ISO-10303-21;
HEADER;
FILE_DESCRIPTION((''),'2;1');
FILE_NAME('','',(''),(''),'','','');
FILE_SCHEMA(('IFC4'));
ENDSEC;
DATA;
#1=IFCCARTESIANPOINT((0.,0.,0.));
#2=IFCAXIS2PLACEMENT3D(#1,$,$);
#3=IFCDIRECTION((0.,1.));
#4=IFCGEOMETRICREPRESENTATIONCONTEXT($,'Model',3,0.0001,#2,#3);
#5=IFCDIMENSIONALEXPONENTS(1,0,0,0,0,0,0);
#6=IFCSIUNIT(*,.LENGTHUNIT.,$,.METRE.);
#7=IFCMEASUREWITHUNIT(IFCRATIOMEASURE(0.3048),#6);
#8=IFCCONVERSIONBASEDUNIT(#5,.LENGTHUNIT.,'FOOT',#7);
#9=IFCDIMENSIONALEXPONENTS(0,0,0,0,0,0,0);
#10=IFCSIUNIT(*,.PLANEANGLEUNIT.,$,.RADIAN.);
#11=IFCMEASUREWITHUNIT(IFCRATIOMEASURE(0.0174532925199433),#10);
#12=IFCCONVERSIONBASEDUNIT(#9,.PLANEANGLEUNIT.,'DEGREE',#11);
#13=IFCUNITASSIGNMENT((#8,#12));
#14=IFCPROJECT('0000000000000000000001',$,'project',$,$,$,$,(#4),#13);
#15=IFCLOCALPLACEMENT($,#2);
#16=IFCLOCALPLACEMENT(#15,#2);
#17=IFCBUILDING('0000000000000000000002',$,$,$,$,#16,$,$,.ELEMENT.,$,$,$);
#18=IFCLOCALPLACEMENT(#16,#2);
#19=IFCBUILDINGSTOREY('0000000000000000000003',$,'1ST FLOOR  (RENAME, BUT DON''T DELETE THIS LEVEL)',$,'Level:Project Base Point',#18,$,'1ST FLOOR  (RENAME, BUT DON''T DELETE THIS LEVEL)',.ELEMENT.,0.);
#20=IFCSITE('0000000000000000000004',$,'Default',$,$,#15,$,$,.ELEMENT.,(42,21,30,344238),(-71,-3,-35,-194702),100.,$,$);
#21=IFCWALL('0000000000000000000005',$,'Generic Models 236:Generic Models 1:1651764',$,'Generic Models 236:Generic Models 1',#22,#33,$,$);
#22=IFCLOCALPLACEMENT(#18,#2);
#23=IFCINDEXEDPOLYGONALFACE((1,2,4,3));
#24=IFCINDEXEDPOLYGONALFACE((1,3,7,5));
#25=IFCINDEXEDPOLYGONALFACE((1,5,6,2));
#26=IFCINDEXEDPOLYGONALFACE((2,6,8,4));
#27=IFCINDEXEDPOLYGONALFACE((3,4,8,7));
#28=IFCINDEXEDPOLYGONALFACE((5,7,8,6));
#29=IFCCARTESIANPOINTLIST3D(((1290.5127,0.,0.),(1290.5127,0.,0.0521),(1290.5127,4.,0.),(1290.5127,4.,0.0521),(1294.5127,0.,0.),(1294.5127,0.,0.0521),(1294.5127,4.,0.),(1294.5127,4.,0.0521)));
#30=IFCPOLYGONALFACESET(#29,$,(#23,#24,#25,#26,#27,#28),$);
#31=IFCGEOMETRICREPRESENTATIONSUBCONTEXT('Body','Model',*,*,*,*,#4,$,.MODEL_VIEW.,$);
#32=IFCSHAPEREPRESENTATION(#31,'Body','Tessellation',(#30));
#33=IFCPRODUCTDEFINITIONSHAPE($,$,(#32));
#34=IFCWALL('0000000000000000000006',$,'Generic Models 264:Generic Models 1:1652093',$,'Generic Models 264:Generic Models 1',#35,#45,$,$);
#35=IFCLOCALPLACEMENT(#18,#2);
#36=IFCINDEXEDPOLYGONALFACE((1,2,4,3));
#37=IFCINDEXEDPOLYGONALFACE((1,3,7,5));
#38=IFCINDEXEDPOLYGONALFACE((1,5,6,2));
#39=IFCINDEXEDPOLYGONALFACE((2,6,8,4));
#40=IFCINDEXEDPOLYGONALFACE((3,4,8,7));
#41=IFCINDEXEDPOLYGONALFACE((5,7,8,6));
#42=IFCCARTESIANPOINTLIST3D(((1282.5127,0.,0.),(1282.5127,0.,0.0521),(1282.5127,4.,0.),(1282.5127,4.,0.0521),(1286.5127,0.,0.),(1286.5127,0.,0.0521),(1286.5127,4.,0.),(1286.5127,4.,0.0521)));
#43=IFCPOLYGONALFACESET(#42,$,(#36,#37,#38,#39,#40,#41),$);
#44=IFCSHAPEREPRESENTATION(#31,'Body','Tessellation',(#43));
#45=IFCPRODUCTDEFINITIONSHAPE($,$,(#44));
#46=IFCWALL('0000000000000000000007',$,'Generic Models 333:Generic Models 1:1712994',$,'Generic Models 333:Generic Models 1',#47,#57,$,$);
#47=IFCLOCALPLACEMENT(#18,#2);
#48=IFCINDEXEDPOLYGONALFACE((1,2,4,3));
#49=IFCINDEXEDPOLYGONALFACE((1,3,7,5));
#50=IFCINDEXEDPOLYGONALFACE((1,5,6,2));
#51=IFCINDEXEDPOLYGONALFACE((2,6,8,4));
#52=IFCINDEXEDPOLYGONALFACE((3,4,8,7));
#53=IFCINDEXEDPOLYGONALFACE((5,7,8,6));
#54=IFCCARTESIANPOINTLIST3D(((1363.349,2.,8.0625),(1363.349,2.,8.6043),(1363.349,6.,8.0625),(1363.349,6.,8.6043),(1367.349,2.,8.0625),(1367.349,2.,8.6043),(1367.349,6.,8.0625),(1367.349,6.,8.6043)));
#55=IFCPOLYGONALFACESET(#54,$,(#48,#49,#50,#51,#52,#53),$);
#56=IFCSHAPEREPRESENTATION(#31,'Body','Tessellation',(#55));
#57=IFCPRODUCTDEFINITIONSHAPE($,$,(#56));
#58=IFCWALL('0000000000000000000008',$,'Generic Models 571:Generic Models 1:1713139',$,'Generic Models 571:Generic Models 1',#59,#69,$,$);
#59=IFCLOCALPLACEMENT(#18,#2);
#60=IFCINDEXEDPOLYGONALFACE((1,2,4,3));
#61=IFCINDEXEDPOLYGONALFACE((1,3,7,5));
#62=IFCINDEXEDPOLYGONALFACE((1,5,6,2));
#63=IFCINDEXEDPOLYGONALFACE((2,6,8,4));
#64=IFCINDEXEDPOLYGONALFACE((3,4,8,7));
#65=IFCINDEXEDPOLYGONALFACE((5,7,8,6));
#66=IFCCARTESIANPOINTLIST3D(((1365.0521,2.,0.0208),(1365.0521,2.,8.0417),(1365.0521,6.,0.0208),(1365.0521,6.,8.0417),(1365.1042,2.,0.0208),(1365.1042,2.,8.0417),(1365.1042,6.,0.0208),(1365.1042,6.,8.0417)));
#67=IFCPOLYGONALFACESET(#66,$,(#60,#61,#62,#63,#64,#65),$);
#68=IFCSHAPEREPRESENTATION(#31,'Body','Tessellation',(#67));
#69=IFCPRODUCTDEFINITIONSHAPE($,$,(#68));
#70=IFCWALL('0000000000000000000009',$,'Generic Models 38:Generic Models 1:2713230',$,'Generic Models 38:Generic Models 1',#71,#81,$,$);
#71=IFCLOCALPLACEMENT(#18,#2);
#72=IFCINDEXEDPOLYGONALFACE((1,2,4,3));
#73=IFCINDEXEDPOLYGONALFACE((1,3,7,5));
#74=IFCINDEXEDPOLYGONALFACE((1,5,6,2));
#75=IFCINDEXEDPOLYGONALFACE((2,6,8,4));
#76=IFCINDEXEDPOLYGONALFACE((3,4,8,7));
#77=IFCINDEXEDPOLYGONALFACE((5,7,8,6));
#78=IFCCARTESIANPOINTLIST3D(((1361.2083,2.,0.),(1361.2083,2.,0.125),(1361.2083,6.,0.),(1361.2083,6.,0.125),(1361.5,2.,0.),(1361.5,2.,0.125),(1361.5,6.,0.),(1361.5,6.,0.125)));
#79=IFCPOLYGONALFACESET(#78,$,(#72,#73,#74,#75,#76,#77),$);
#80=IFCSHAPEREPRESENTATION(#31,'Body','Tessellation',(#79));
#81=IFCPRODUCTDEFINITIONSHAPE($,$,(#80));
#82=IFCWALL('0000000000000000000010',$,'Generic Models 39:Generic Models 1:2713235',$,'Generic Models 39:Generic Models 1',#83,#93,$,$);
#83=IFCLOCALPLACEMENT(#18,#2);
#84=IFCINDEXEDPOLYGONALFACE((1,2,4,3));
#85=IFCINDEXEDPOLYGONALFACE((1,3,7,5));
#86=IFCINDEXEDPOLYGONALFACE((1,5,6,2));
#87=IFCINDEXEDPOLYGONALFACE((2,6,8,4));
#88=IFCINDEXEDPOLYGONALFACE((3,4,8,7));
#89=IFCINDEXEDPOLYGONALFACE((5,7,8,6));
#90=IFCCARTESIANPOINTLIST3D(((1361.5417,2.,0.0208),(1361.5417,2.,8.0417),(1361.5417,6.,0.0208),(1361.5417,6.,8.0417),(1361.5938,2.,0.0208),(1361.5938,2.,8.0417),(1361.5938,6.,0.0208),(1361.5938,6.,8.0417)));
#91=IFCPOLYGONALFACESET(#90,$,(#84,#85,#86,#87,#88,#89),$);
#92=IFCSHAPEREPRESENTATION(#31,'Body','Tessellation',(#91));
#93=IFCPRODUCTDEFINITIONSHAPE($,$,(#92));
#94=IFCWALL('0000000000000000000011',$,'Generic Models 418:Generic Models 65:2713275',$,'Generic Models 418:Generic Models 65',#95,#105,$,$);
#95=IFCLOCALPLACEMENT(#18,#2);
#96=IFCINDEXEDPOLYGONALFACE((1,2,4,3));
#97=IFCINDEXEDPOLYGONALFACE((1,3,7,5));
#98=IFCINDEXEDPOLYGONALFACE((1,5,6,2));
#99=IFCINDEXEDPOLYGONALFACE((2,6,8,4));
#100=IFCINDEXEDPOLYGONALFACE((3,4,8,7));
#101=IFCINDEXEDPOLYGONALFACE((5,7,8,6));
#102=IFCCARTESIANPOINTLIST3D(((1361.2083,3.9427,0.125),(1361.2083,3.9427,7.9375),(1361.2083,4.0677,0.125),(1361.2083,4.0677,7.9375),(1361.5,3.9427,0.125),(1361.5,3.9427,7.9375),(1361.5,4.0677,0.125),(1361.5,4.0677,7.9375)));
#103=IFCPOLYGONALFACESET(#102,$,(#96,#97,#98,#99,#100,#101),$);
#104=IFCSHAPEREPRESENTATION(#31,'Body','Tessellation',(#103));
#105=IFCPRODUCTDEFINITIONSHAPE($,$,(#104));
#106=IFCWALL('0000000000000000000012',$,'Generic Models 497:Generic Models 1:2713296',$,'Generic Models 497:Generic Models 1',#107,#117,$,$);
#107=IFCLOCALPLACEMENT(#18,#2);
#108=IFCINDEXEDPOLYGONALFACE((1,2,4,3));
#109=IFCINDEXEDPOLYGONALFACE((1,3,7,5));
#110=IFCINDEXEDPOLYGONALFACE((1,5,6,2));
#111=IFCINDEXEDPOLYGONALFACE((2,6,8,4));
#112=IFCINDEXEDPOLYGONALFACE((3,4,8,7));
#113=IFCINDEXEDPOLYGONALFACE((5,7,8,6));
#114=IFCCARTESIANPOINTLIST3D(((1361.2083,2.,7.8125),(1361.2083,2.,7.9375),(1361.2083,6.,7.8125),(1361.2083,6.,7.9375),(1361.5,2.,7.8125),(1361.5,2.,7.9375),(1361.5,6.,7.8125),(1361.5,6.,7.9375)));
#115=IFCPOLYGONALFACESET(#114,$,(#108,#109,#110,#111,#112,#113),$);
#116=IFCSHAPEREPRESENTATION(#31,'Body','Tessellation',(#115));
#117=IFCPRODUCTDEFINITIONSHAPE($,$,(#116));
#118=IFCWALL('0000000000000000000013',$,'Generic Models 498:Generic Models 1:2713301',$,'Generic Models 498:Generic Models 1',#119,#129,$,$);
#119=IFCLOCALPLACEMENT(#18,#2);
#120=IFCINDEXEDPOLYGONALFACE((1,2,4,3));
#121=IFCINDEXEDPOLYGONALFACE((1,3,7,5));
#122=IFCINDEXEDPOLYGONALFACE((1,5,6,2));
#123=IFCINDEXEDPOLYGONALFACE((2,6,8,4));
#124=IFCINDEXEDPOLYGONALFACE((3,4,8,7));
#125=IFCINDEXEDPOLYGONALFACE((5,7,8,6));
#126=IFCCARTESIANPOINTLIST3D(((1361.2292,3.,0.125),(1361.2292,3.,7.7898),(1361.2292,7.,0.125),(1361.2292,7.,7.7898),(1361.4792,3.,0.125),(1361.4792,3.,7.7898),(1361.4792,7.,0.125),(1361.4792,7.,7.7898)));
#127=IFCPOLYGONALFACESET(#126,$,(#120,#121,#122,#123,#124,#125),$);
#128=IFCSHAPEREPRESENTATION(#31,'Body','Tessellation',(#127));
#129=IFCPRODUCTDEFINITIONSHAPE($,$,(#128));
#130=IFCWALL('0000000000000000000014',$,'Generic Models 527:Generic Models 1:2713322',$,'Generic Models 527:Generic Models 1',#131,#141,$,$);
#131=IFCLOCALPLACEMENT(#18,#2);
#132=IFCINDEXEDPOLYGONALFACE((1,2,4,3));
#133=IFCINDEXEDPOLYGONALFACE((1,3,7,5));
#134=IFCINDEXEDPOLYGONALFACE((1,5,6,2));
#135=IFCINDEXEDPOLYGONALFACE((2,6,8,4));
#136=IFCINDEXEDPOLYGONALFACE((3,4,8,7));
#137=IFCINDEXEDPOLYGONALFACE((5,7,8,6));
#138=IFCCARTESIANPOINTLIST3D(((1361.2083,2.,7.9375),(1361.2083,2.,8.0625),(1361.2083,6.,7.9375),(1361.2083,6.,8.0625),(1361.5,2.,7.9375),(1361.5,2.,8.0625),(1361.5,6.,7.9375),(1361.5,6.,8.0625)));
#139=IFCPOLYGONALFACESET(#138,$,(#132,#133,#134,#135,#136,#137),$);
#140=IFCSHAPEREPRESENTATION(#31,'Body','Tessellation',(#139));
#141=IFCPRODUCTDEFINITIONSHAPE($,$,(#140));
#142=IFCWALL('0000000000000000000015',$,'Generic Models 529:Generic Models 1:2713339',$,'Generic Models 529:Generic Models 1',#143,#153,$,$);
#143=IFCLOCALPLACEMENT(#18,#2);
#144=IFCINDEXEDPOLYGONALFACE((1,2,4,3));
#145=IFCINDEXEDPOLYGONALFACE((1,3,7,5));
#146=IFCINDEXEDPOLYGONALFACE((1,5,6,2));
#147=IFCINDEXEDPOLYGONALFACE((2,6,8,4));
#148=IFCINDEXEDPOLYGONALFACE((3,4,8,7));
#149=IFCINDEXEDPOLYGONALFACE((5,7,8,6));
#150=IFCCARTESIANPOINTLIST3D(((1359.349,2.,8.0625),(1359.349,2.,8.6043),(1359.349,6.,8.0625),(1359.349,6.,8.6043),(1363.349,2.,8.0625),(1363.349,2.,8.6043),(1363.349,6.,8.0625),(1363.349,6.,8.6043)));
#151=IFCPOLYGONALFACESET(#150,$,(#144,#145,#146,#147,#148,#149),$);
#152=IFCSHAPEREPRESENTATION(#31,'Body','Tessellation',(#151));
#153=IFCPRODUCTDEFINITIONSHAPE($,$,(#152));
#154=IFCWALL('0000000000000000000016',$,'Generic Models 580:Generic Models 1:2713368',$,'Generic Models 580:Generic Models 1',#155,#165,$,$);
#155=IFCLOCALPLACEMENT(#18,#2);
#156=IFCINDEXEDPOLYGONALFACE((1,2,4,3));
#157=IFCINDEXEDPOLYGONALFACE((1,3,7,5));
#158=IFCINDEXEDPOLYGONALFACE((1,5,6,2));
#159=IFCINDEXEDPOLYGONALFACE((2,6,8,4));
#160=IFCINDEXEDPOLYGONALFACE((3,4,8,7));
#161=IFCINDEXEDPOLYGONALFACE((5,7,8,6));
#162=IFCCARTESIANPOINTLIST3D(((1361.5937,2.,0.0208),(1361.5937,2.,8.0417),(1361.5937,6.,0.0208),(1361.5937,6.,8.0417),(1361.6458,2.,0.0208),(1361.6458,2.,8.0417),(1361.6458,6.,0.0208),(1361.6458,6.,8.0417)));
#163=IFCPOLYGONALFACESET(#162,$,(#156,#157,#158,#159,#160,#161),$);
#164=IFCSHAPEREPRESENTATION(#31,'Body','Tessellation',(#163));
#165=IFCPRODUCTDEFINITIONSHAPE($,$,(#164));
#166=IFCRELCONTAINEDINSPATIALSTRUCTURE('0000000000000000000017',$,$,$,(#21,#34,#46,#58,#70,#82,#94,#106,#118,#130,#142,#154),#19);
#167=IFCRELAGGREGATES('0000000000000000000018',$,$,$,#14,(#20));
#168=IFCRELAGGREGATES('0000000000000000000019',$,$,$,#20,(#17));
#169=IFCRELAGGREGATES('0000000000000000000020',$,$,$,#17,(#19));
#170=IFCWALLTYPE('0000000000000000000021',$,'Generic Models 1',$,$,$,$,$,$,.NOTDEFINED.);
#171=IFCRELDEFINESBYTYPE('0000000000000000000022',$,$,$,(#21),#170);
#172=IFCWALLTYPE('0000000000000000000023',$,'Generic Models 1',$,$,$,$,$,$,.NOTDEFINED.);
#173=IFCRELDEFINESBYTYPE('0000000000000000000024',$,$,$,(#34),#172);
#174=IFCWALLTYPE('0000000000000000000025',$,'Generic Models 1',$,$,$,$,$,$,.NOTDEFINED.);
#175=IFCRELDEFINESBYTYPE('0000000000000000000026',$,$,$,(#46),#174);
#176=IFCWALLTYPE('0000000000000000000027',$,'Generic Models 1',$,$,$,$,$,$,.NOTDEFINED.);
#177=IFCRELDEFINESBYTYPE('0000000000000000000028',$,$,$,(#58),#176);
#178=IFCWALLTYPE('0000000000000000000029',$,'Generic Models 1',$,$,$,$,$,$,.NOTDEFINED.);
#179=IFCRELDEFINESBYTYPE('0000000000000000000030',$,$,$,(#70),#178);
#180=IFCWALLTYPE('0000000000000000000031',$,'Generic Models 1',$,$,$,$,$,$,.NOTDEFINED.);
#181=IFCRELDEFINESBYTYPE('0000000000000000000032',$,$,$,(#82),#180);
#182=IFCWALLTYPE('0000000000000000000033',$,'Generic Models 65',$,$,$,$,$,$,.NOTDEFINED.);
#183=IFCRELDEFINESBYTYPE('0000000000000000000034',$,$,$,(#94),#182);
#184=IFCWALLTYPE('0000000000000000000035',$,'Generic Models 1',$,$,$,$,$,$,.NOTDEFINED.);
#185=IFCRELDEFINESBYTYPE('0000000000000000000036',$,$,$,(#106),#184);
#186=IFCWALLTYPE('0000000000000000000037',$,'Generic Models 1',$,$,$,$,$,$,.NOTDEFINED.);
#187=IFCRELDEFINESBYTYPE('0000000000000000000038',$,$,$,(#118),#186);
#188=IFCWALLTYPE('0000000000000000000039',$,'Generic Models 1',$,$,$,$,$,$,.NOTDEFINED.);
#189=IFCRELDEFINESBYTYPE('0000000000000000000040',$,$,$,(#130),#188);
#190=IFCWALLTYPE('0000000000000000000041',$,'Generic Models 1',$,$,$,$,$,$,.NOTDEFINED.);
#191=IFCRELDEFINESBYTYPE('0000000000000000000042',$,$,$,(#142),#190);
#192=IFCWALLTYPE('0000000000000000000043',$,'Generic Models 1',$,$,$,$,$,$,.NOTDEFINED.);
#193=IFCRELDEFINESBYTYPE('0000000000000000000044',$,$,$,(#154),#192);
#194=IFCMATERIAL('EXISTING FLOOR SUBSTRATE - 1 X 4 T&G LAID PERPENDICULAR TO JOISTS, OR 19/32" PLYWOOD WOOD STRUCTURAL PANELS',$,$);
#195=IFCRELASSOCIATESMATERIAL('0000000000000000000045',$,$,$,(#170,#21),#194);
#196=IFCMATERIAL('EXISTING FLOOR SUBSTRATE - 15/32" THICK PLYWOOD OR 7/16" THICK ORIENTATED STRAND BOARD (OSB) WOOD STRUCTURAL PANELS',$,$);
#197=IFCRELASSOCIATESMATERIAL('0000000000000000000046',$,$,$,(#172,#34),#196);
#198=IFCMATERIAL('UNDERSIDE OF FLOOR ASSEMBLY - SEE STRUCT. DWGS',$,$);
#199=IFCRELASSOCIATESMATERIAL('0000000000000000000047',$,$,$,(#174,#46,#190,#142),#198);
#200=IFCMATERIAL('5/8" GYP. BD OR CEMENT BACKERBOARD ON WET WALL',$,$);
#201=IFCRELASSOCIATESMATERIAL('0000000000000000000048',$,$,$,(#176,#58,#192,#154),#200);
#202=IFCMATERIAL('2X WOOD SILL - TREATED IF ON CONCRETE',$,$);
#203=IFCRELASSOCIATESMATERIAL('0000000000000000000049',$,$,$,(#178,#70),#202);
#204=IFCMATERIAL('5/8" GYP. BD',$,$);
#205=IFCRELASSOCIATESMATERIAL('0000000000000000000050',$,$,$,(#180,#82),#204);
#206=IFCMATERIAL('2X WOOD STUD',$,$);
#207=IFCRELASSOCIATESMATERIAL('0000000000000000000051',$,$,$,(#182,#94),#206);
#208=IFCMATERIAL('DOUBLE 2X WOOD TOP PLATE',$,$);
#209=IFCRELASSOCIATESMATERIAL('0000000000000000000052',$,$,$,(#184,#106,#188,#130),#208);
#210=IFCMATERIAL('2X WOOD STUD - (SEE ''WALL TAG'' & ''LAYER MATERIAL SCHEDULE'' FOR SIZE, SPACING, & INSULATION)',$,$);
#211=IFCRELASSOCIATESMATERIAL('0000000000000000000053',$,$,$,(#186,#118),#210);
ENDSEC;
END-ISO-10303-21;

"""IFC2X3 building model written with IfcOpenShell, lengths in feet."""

from ifc_helpers import new_model, entity, si_unit, converted_unit, direction, frame, frame_2d, origin, origin_2d_with_axis, place, context, subcontext, project, spatial, rectangle, extrude, material, type_object, element, save


model = new_model("IFC2X3")

# Units and contexts
model_context = context("Model", 3, precision=0.0001, world=origin(), true_north=direction((0.0, 1.0)))
body_context = subcontext(model_context, "Body", "Model", "MODEL_VIEW")
ifc_project = project(units=[converted_unit("LENGTHUNIT", "FOOT", entity("IfcRatioMeasure", 0.3048), si_unit("LENGTHUNIT", "METRE"), dimensions=[1, 0, 0, 0, 0, 0, 0]), converted_unit("PLANEANGLEUNIT", "DEGREE", entity("IfcRatioMeasure", 0.0174532925199433), si_unit("PLANEANGLEUNIT", "RADIAN"), dimensions=[0, 0, 0, 0, 0, 0, 0])], contexts=[model_context])

# Site, building, storey
site_placement = place(None, origin())
site = spatial("IfcSite", under=ifc_project, at=site_placement, Name="Default", CompositionType="ELEMENT", RefLatitude=(42, 21, 30, 344238), RefLongitude=(-71, -3, -35, -194702), RefElevation=100.0)
building_placement = place(site_placement, origin())
building = spatial("IfcBuilding", under=site, at=building_placement, CompositionType="ELEMENT")
storey_placement = place(building_placement, origin())
storey = spatial("IfcBuildingStorey", under=building, at=storey_placement, Name="1ST FLOOR  (RENAME, BUT DON'T DELETE THIS LEVEL)", ObjectType="Level:Project Base Point", LongName="1ST FLOOR  (RENAME, BUT DON'T DELETE THIS LEVEL)", CompositionType="ELEMENT", Elevation=0.0)

# Walls
ifc_material_1 = material(Name="EXISTING FLOOR SUBSTRATE - 1 X 4 T&G LAID PERPENDICULAR TO JOISTS, OR 19/32\" PLYWOOD WOOD STRUCTURAL PANELS")
wall_type_1 = type_object("IfcWallType", Name="Generic Models 1", PredefinedType="NOTDEFINED", material=ifc_material_1)
wall_1_placement = place(storey_placement, frame((1290.5127, 0.0, 0.0), z_axis=(0.0, 0.0, 1.0), x_axis=(0.0, 1.0, 0.0)))
element("IfcWall", 1, at=wall_1_placement, inside=storey, type_object=wall_type_1, material=ifc_material_1, Name="Generic Models 236:Generic Models 1:1651764", ObjectType="Generic Models 236:Generic Models 1", context=body_context, shape_type="SweptSolid", body=[
    extrude(rectangle(XDim=4.0, YDim=4.0, at=origin_2d_with_axis()), frame((2.0, -2.0, 0.0)), (0.0, 0.0, 1.0), 0.0521),
])
ifc_material_2 = material(Name="EXISTING FLOOR SUBSTRATE - 15/32\" THICK PLYWOOD OR 7/16\" THICK ORIENTATED STRAND BOARD (OSB) WOOD STRUCTURAL PANELS")
wall_type_2 = type_object("IfcWallType", Name="Generic Models 1", PredefinedType="NOTDEFINED", material=ifc_material_2)
wall_2_placement = place(storey_placement, frame((1282.5127, 0.0, 0.0), z_axis=(0.0, 0.0, 1.0), x_axis=(0.0, 1.0, 0.0)))
element("IfcWall", 2, at=wall_2_placement, inside=storey, type_object=wall_type_2, material=ifc_material_2, Name="Generic Models 264:Generic Models 1:1652093", ObjectType="Generic Models 264:Generic Models 1", context=body_context, shape_type="SweptSolid", body=[
    extrude(rectangle(XDim=4.0, YDim=4.0, at=origin_2d_with_axis()), frame((2.0, -2.0, 0.0)), (0.0, 0.0, 1.0), 0.0521),
])
ifc_material_3 = material(Name="UNDERSIDE OF FLOOR ASSEMBLY - SEE STRUCT. DWGS")
wall_type_3 = type_object("IfcWallType", Name="Generic Models 1", PredefinedType="NOTDEFINED", material=ifc_material_3)
wall_3_placement = place(storey_placement, frame((1363.349, 2.0, 8.0625), z_axis=(0.0, 0.0, 1.0), x_axis=(0.0, 1.0, 0.0)))
element("IfcWall", 3, at=wall_3_placement, inside=storey, type_object=wall_type_3, material=ifc_material_3, Name="Generic Models 333:Generic Models 1:1712994", ObjectType="Generic Models 333:Generic Models 1", context=body_context, shape_type="SweptSolid", body=[
    extrude(rectangle(XDim=4.0, YDim=4.0, at=origin_2d_with_axis()), frame((2.0, -2.0, 0.0)), (0.0, 0.0, 1.0), 0.5418),
])
ifc_material_4 = material(Name="5/8\" GYP. BD OR CEMENT BACKERBOARD ON WET WALL")
wall_type_4 = type_object("IfcWallType", Name="Generic Models 1", PredefinedType="NOTDEFINED", material=ifc_material_4)
wall_4_placement = place(storey_placement, frame((1365.0521, 2.0, 0.0208), z_axis=(0.0, 0.0, 1.0), x_axis=(0.0, 1.0, 0.0)))
element("IfcWall", 4, at=wall_4_placement, inside=storey, type_object=wall_type_4, material=ifc_material_4, Name="Generic Models 571:Generic Models 1:1713139", ObjectType="Generic Models 571:Generic Models 1", context=body_context, shape_type="SweptSolid", body=[
    extrude(rectangle(XDim=4.0, YDim=0.0521, at=origin_2d_with_axis()), frame((2.0, -0.026, 0.0)), (0.0, 0.0, 1.0), 8.0208),
])
ifc_material_5 = material(Name="2X WOOD SILL - TREATED IF ON CONCRETE")
wall_type_5 = type_object("IfcWallType", Name="Generic Models 1", PredefinedType="NOTDEFINED", material=ifc_material_5)
wall_5_placement = place(storey_placement, frame((1361.2083, 2.0, 0.0), z_axis=(0.0, 0.0, 1.0), x_axis=(0.0, 1.0, 0.0)))
element("IfcWall", 5, at=wall_5_placement, inside=storey, type_object=wall_type_5, material=ifc_material_5, Name="Generic Models 38:Generic Models 1:2713230", ObjectType="Generic Models 38:Generic Models 1", context=body_context, shape_type="SweptSolid", body=[
    extrude(rectangle(XDim=4.0, YDim=0.2917, at=frame_2d((0.0, 0.0), x_axis=(1.0, 0.0))), frame((2.0, -0.1458, 0.0)), (0.0, 0.0, 1.0), 0.125),
])
ifc_material_6 = material(Name="5/8\" GYP. BD")
wall_type_6 = type_object("IfcWallType", Name="Generic Models 1", PredefinedType="NOTDEFINED", material=ifc_material_6)
wall_6_placement = place(storey_placement, frame((1361.5417, 2.0, 0.0208), z_axis=(0.0, 0.0, 1.0), x_axis=(0.0, 1.0, 0.0)))
element("IfcWall", 6, at=wall_6_placement, inside=storey, type_object=wall_type_6, material=ifc_material_6, Name="Generic Models 39:Generic Models 1:2713235", ObjectType="Generic Models 39:Generic Models 1", context=body_context, shape_type="SweptSolid", body=[
    extrude(rectangle(XDim=4.0, YDim=0.0521, at=frame_2d((0.0, 0.0), x_axis=(1.0, 0.0))), frame((2.0, -0.026, 0.0)), (0.0, 0.0, 1.0), 8.0208),
])
ifc_material_7 = material(Name="2X WOOD STUD")
wall_type_7 = type_object("IfcWallType", Name="Generic Models 65", PredefinedType="NOTDEFINED", material=ifc_material_7)
wall_7_placement = place(storey_placement, frame((1361.2083, 3.9427, 0.125)))
element("IfcWall", 7, at=wall_7_placement, inside=storey, type_object=wall_type_7, material=ifc_material_7, Name="Generic Models 418:Generic Models 65:2713275", ObjectType="Generic Models 418:Generic Models 65", context=body_context, shape_type="SweptSolid", body=[
    extrude(rectangle(XDim=0.125, YDim=0.2917, at=frame_2d((0.0, 0.0), x_axis=(1.0, 0.0))), frame((0.1458, 0.0625, 0.0), z_axis=(0.0, 0.0, 1.0), x_axis=(0.0, 1.0, 0.0)), (0.0, 0.0, 1.0), 7.8125),
])
ifc_material_8 = material(Name="DOUBLE 2X WOOD TOP PLATE")
wall_type_8 = type_object("IfcWallType", Name="Generic Models 1", PredefinedType="NOTDEFINED", material=ifc_material_8)
wall_8_placement = place(storey_placement, frame((1361.2083, 2.0, 7.8125), z_axis=(0.0, 0.0, 1.0), x_axis=(0.0, 1.0, 0.0)))
element("IfcWall", 8, at=wall_8_placement, inside=storey, type_object=wall_type_8, material=ifc_material_8, Name="Generic Models 497:Generic Models 1:2713296", ObjectType="Generic Models 497:Generic Models 1", context=body_context, shape_type="SweptSolid", body=[
    extrude(rectangle(XDim=4.0, YDim=0.2917, at=frame_2d((0.0, 0.0), x_axis=(1.0, 0.0))), frame((2.0, -0.1458, 0.0)), (0.0, 0.0, 1.0), 0.125),
])
ifc_material_9 = material(Name="2X WOOD STUD - (SEE 'WALL TAG' & 'LAYER MATERIAL SCHEDULE' FOR SIZE, SPACING, & INSULATION)")
wall_type_9 = type_object("IfcWallType", Name="Generic Models 1", PredefinedType="NOTDEFINED", material=ifc_material_9)
wall_9_placement = place(storey_placement, frame((1361.2292, 3.0, 0.125), z_axis=(0.0, 0.0, 1.0), x_axis=(0.0, 1.0, 0.0)))
element("IfcWall", 9, at=wall_9_placement, inside=storey, type_object=wall_type_9, material=ifc_material_9, Name="Generic Models 498:Generic Models 1:2713301", ObjectType="Generic Models 498:Generic Models 1", context=body_context, shape_type="SweptSolid", body=[
    extrude(rectangle(XDim=4.0, YDim=0.25, at=frame_2d((0.0, 0.0), x_axis=(1.0, 0.0))), frame((2.0, -0.125, 0.0)), (0.0, 0.0, 1.0), 7.6648),
])
wall_type_10 = type_object("IfcWallType", Name="Generic Models 1", PredefinedType="NOTDEFINED", material=ifc_material_8)
wall_10_placement = place(storey_placement, frame((1361.2083, 2.0, 7.9375), z_axis=(0.0, 0.0, 1.0), x_axis=(0.0, 1.0, 0.0)))
element("IfcWall", 10, at=wall_10_placement, inside=storey, type_object=wall_type_10, material=ifc_material_8, Name="Generic Models 527:Generic Models 1:2713322", ObjectType="Generic Models 527:Generic Models 1", context=body_context, shape_type="SweptSolid", body=[
    extrude(rectangle(XDim=4.0, YDim=0.2917, at=frame_2d((0.0, 0.0), x_axis=(1.0, 0.0))), frame((2.0, -0.1458, 0.0)), (0.0, 0.0, 1.0), 0.125),
])
wall_type_11 = type_object("IfcWallType", Name="Generic Models 1", PredefinedType="NOTDEFINED", material=ifc_material_3)
wall_11_placement = place(storey_placement, frame((1359.349, 2.0, 8.0625), z_axis=(0.0, 0.0, 1.0), x_axis=(0.0, 1.0, 0.0)))
element("IfcWall", 11, at=wall_11_placement, inside=storey, type_object=wall_type_11, material=ifc_material_3, Name="Generic Models 529:Generic Models 1:2713339", ObjectType="Generic Models 529:Generic Models 1", context=body_context, shape_type="SweptSolid", body=[
    extrude(rectangle(XDim=4.0, YDim=4.0, at=origin_2d_with_axis()), frame((2.0, -2.0, 0.0)), (0.0, 0.0, 1.0), 0.5418),
])
wall_type_12 = type_object("IfcWallType", Name="Generic Models 1", PredefinedType="NOTDEFINED", material=ifc_material_4)
wall_12_placement = place(storey_placement, frame((1361.5938, 2.0, 0.0208), z_axis=(0.0, 0.0, 1.0), x_axis=(0.0, 1.0, 0.0)))
element("IfcWall", 12, at=wall_12_placement, inside=storey, type_object=wall_type_12, material=ifc_material_4, Name="Generic Models 580:Generic Models 1:2713368", ObjectType="Generic Models 580:Generic Models 1", context=body_context, shape_type="SweptSolid", body=[
    extrude(rectangle(XDim=4.0, YDim=0.0521, at=frame_2d((0.0, 0.0), x_axis=(1.0, 0.0))), frame((2.0, -0.026, 0.0)), (0.0, 0.0, 1.0), 8.0208),
])

save(model, "model.ifc")
